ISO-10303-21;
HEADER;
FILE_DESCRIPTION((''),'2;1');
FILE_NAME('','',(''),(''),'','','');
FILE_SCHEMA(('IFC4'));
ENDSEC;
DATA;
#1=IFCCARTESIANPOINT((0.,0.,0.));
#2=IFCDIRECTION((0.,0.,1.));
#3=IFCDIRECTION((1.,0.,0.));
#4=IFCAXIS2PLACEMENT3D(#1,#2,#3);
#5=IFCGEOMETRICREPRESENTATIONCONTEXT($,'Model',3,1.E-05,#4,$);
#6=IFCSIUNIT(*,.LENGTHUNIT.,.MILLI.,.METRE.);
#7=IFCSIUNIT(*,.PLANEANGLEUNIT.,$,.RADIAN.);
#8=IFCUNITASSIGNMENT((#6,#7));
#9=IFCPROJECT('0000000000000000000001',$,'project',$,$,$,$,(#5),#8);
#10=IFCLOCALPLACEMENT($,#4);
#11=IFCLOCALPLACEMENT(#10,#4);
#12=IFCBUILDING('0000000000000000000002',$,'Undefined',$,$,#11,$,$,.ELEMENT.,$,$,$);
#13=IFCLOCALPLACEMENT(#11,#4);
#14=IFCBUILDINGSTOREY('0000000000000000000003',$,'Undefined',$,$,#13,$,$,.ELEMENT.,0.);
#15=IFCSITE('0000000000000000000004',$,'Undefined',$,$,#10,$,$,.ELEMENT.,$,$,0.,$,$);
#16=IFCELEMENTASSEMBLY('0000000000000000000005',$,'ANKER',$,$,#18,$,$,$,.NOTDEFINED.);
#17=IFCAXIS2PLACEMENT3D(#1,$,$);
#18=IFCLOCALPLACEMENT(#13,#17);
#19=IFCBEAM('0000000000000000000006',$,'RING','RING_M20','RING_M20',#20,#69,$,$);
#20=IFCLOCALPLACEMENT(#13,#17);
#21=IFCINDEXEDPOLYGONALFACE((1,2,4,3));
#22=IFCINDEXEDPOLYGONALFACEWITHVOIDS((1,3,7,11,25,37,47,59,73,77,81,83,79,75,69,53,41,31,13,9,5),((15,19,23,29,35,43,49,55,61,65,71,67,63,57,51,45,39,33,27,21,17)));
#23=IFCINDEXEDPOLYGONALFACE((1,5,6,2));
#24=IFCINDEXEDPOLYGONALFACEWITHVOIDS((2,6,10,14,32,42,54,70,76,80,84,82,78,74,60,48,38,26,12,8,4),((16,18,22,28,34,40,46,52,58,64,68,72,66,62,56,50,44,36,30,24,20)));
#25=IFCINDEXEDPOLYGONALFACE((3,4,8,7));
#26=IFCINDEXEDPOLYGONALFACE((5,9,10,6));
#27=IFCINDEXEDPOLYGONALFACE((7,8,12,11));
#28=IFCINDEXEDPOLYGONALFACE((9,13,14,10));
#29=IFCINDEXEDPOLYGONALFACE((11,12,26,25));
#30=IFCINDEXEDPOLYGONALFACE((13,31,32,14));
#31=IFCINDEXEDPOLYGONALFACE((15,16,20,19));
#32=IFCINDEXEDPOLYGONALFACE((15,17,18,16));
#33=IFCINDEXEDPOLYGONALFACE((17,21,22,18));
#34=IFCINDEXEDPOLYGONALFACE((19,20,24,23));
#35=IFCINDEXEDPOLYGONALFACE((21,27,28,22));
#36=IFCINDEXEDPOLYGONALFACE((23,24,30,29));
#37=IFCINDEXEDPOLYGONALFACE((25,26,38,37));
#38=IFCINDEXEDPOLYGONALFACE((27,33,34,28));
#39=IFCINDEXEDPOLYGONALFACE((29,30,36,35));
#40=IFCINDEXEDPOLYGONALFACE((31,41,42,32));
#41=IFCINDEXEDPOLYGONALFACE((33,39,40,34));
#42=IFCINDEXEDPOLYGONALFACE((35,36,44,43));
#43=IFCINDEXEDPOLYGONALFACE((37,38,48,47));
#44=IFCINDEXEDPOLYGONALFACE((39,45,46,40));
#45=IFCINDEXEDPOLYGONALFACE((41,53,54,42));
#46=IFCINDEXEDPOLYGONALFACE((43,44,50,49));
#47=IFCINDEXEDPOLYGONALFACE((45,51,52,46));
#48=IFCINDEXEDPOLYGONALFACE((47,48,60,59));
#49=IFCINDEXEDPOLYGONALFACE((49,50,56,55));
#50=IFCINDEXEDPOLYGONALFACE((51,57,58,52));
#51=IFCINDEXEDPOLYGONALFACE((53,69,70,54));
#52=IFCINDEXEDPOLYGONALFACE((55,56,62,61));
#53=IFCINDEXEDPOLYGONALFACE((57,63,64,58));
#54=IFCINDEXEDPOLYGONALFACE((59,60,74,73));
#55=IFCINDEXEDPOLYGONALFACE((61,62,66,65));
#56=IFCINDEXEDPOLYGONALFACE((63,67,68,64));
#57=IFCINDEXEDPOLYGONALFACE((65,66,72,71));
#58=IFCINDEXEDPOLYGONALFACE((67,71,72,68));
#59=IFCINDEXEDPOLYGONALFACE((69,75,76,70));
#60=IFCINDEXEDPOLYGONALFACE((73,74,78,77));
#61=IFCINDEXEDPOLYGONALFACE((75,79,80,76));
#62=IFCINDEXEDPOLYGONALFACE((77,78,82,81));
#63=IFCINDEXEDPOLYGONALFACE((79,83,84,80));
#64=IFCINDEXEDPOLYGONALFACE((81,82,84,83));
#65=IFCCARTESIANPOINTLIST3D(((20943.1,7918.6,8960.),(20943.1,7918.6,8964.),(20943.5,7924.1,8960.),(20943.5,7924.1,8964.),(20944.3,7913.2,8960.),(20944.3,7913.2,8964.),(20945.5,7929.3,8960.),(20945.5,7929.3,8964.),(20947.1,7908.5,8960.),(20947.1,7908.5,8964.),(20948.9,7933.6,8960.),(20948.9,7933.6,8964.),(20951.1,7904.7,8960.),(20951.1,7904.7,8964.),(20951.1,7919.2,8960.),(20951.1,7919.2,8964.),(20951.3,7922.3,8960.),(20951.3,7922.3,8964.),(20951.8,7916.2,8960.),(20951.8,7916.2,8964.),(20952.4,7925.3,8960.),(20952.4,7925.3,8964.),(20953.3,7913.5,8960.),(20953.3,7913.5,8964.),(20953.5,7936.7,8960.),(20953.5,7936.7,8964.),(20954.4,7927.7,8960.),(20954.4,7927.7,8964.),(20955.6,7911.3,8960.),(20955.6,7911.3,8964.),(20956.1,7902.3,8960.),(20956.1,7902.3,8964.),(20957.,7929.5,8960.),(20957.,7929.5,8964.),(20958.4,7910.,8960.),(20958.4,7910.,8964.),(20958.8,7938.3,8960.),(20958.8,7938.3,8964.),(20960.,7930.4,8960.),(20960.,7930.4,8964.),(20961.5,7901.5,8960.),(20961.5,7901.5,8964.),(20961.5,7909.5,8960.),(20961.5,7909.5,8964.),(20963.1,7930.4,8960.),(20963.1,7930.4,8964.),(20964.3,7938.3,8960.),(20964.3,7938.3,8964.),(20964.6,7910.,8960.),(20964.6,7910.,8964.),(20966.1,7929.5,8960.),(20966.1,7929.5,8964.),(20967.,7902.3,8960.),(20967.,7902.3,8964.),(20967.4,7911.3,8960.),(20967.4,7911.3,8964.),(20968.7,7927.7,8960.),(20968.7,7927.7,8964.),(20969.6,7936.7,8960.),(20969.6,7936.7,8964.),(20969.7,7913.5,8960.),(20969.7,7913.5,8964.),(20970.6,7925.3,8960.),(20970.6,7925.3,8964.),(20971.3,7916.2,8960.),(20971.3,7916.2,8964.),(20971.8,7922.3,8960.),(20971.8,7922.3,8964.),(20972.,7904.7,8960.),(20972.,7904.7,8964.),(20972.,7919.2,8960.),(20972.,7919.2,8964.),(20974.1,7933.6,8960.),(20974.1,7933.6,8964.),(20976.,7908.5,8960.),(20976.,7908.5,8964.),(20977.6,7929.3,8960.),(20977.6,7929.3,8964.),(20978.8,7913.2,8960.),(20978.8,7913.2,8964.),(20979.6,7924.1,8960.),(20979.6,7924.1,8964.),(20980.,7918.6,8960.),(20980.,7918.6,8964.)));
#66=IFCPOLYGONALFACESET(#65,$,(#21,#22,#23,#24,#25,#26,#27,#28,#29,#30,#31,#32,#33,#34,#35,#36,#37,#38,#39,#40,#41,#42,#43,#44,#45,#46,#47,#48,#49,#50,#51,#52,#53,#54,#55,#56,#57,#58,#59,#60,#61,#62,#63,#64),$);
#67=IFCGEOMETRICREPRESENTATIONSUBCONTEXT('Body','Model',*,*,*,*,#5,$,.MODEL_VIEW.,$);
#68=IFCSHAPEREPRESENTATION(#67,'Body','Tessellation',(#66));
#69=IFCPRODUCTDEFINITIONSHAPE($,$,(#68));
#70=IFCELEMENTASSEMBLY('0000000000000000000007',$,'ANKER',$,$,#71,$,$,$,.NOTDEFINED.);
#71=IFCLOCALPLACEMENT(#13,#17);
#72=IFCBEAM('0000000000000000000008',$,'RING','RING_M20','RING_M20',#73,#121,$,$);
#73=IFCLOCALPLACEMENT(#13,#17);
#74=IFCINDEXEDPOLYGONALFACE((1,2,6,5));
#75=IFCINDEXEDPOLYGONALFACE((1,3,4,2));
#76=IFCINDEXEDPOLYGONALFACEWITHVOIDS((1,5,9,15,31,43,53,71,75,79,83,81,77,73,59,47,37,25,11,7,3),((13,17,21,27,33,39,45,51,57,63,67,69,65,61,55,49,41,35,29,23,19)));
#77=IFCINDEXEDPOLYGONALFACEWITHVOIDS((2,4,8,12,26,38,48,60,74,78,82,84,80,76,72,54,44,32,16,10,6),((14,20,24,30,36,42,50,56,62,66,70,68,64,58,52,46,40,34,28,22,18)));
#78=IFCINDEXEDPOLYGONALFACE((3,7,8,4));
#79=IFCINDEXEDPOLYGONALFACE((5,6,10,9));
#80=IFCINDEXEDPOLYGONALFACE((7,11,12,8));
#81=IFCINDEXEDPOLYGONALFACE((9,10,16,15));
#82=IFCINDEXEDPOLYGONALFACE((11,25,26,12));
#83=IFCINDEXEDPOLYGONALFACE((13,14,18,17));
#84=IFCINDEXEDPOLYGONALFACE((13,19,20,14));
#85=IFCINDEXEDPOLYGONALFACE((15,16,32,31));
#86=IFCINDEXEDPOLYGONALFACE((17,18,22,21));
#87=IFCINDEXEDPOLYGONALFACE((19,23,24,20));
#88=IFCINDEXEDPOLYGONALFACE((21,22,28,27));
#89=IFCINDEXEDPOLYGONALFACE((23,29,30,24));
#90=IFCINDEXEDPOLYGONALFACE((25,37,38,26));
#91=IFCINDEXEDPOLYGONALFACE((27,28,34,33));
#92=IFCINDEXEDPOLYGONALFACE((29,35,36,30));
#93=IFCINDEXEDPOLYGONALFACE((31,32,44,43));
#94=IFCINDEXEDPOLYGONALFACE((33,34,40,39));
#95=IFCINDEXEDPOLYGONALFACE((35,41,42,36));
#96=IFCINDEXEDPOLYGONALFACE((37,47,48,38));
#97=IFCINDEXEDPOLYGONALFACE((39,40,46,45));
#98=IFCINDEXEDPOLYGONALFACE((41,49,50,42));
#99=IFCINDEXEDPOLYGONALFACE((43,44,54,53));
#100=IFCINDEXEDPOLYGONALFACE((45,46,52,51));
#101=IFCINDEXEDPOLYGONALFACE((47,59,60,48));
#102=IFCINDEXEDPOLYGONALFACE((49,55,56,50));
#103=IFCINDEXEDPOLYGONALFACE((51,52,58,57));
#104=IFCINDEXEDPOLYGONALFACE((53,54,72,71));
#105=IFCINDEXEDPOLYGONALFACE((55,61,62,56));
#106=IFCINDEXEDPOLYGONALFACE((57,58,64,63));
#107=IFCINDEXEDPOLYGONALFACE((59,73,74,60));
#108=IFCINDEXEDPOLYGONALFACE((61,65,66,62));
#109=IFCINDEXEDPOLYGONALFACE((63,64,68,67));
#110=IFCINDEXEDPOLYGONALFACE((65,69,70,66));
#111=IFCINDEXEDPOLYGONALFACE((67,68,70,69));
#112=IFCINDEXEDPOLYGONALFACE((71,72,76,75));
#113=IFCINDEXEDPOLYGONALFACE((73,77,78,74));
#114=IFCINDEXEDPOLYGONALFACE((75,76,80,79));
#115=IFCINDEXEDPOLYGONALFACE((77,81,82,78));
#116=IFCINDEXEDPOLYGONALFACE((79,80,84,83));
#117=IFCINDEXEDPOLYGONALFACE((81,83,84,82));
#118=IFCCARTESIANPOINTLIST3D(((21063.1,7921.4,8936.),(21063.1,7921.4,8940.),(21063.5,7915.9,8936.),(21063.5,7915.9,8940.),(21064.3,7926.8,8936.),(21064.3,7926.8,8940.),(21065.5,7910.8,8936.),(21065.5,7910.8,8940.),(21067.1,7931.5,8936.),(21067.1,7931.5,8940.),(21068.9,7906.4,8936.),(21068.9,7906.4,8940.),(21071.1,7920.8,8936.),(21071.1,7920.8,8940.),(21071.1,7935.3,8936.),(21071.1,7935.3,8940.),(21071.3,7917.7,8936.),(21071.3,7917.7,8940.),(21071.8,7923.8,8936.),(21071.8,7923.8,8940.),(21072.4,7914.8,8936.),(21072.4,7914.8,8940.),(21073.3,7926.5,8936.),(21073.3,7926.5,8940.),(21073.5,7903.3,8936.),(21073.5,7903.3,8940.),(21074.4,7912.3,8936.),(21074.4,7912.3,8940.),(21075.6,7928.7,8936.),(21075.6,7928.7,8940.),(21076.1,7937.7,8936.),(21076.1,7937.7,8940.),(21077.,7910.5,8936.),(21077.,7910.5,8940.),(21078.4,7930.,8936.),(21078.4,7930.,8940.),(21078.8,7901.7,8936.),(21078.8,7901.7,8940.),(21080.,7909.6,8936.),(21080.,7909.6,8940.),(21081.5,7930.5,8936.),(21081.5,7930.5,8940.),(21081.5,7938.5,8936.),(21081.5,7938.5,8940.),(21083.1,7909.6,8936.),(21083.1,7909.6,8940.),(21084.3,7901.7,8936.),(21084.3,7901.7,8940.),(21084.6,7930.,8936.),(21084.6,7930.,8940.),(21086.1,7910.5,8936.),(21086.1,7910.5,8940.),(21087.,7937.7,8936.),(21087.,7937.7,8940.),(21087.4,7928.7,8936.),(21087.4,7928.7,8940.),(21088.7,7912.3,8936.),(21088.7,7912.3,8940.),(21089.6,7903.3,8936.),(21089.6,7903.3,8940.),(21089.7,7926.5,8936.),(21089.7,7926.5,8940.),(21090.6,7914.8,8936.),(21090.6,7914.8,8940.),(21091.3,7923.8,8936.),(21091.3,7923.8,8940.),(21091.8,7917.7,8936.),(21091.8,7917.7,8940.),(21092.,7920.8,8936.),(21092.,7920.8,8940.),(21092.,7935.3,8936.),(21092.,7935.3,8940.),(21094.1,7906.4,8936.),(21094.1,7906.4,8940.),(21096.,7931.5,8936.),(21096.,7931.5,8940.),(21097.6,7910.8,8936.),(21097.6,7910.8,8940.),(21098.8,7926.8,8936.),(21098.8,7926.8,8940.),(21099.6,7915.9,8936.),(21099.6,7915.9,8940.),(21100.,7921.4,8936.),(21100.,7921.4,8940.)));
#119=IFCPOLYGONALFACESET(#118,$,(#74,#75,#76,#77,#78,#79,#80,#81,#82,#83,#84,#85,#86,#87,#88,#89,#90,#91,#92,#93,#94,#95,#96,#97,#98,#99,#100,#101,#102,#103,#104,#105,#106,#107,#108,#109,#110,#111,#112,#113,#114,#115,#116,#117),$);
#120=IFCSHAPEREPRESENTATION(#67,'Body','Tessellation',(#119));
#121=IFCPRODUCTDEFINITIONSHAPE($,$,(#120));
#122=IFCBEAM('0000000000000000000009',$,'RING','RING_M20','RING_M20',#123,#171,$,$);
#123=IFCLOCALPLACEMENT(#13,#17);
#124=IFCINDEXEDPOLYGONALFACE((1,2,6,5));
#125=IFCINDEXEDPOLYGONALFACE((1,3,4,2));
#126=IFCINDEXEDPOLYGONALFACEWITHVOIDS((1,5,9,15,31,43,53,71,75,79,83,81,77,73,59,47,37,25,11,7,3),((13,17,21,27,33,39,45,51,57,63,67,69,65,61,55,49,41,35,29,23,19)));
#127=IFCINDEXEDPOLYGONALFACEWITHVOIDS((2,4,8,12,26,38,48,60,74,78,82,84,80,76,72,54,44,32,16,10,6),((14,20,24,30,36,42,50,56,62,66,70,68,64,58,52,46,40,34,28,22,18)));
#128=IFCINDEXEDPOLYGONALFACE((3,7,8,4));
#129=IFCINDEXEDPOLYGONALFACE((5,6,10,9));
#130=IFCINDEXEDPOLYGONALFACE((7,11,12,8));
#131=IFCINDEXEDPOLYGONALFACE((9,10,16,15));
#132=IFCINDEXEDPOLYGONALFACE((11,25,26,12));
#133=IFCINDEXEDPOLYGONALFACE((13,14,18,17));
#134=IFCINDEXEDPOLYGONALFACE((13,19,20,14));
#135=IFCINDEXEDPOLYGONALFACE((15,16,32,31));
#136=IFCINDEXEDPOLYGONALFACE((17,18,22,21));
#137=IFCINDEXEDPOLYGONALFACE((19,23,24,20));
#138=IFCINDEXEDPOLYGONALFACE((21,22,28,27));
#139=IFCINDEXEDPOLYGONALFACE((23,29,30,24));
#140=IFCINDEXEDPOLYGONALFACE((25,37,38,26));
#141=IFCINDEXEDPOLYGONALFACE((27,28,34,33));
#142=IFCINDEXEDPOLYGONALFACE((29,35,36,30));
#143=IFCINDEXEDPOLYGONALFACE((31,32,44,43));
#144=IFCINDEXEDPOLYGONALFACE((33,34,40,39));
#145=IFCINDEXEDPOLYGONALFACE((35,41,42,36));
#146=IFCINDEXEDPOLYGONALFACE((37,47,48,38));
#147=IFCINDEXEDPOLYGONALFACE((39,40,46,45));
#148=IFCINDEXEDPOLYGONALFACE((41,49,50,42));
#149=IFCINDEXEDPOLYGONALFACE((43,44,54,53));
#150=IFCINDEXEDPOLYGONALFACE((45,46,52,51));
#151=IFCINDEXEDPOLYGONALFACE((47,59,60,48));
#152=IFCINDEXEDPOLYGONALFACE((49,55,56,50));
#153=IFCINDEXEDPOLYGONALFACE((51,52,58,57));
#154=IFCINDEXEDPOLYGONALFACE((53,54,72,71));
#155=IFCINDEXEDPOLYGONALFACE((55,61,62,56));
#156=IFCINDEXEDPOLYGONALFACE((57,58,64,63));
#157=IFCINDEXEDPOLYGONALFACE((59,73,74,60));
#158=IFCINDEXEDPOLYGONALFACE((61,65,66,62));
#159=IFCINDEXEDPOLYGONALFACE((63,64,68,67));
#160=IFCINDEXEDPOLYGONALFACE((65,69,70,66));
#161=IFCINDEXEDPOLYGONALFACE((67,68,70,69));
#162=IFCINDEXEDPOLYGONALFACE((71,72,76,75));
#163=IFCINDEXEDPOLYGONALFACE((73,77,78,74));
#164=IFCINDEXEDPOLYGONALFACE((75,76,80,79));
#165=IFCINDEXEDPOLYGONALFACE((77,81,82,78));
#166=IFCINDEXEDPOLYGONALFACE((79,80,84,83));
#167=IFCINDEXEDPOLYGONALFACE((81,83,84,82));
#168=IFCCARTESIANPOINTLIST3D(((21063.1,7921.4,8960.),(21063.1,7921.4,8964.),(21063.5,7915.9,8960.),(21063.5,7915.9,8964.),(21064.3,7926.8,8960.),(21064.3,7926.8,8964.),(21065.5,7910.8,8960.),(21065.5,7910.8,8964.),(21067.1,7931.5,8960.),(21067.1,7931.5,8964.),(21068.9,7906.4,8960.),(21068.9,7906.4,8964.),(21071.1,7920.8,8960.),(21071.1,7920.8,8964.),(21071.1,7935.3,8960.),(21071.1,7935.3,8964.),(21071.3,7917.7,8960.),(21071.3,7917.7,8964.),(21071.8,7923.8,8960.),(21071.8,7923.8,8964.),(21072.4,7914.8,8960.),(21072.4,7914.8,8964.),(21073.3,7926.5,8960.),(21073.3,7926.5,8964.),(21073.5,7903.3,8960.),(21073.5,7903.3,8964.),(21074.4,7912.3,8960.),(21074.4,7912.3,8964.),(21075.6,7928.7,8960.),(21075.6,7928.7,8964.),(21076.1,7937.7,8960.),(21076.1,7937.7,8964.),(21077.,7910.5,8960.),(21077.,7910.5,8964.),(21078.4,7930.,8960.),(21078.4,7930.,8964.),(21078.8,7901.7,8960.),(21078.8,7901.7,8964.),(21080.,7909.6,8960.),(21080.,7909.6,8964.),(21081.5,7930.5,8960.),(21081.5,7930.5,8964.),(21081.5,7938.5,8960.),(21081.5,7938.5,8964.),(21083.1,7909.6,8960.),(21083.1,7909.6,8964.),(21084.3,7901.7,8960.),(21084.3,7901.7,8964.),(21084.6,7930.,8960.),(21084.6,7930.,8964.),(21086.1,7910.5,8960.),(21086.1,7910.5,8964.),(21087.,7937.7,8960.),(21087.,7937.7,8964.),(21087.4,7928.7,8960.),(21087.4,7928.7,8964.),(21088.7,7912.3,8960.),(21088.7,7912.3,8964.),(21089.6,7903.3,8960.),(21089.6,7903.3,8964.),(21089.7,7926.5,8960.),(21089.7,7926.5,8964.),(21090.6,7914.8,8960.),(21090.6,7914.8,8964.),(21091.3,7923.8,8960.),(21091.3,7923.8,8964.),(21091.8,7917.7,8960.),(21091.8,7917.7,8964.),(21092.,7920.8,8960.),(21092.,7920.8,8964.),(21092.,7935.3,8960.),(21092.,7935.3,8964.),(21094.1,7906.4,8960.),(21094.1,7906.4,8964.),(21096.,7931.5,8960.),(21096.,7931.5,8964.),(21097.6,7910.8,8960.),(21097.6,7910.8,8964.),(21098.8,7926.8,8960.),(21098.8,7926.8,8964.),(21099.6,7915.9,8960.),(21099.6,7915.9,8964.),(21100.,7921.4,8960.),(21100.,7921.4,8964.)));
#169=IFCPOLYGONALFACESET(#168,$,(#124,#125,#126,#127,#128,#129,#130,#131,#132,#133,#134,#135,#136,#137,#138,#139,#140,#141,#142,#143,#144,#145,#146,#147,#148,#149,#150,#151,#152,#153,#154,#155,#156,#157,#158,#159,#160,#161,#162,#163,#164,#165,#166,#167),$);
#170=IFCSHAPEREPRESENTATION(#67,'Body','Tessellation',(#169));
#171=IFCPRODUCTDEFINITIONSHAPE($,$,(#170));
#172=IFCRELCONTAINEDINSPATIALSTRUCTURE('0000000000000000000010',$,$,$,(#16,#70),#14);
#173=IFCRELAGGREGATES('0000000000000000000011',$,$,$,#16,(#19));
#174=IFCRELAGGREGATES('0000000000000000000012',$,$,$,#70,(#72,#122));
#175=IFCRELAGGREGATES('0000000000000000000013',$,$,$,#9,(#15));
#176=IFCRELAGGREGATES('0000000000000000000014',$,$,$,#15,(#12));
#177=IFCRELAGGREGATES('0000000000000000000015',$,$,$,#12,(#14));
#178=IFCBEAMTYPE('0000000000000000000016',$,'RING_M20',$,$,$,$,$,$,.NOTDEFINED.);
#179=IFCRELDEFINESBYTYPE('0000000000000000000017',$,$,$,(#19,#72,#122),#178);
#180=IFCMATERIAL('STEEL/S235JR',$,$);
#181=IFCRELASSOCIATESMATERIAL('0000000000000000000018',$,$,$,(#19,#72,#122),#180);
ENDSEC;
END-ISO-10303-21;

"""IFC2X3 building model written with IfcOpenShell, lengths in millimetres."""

from ifc_helpers import new_model, si_unit, frame, origin_with_axes, origin_2d_with_axis, place, context, subcontext, project, spatial, hollow_circle, extrude, material, type_object, element, aggregate, save


model = new_model("IFC2X3")

# Units and contexts
model_context = context("Model", 3, precision=1e-05, world=origin_with_axes())
body_context = subcontext(model_context, "Body", "Model", "MODEL_VIEW")
ifc_project = project(units=[si_unit("LENGTHUNIT", "METRE", prefix="MILLI"), si_unit("PLANEANGLEUNIT", "RADIAN")], contexts=[model_context])

# Site, building, storey
site_placement = place(None, origin_with_axes())
site = spatial("IfcSite", under=ifc_project, at=site_placement, Name="Undefined", CompositionType="ELEMENT", RefElevation=0.0)
building_placement = place(site_placement, origin_with_axes())
building = spatial("IfcBuilding", under=site, at=building_placement, Name="Undefined", CompositionType="ELEMENT")
storey_placement = place(building_placement, origin_with_axes())
storey = spatial("IfcBuildingStorey", under=building, at=storey_placement, Name="Undefined", CompositionType="ELEMENT", Elevation=0.0)

# Shared definitions
ifc_material = material(Name="STEEL/S235JR")

# Element assemblies, beams
beam_type_1 = type_object("IfcBeamType", Name="RING_M20", PredefinedType="NOTDEFINED")
assembly_1_placement = place(storey_placement, frame((20961.5, 7920.0, 9010.0), z_axis=(0.0, 1.0, 0.0), x_axis=(0.0, 0.0, -1.0)))
assembly_1 = element("IfcElementAssembly", 1, at=assembly_1_placement, inside=storey, Name="ANKER", PredefinedType="NOTDEFINED")
beam_1_placement = place(storey_placement, frame((20961.5, 7920.0, 8964.0), z_axis=(1.0, 0.0, 0.0), x_axis=(0.0, 0.0, -1.0)))
beam_1 = element("IfcBeam", 2, at=beam_1_placement, type_object=beam_type_1, material=ifc_material, Name="RING", Description="RING_M20", ObjectType="RING_M20", context=body_context, shape_type="SweptSolid", body=[
    extrude(hollow_circle(Radius=18.5, WallThickness=8.0, at=origin_2d_with_axis()), frame((4.0, 0.0, 0.0), z_axis=(-1.0, 0.0, 0.0), x_axis=(0.0, -1.0, 0.0)), (0.0, 0.0, 1.0), 4.0),
])
aggregate(assembly_1, [beam_1])
assembly_2_placement = place(storey_placement, frame((21081.5, 7920.0, 9010.0), z_axis=(0.0, 1.0, 0.0), x_axis=(0.0, 0.0, -1.0)))
assembly_2 = element("IfcElementAssembly", 3, at=assembly_2_placement, inside=storey, Name="ANKER", PredefinedType="NOTDEFINED")
beam_2_placement = place(storey_placement, frame((21081.5, 7920.0, 8940.0), z_axis=(-1.0, 0.0, 0.0), x_axis=(0.0, 0.0, -1.0)))
beam_2 = element("IfcBeam", 4, at=beam_2_placement, type_object=beam_type_1, material=ifc_material, Name="RING", Description="RING_M20", ObjectType="RING_M20", context=body_context, shape_type="SweptSolid", body=[
    extrude(hollow_circle(Radius=18.5, WallThickness=8.0, at=origin_2d_with_axis()), frame((4.0, 0.0, 0.0), z_axis=(-1.0, 0.0, 0.0), x_axis=(0.0, -1.0, 0.0)), (0.0, 0.0, 1.0), 4.0),
])
beam_3_placement = place(storey_placement, frame((21081.5, 7920.0, 8964.0), z_axis=(-1.0, 0.0, 0.0), x_axis=(0.0, 0.0, -1.0)))
beam_3 = element("IfcBeam", 5, at=beam_3_placement, type_object=beam_type_1, material=ifc_material, Name="RING", Description="RING_M20", ObjectType="RING_M20", context=body_context, shape_type="SweptSolid", body=[
    extrude(hollow_circle(Radius=18.5, WallThickness=8.0, at=origin_2d_with_axis()), frame((4.0, 0.0, 0.0), z_axis=(-1.0, 0.0, 0.0), x_axis=(0.0, -1.0, 0.0)), (0.0, 0.0, 1.0), 4.0),
])
aggregate(assembly_2, [beam_2, beam_3])

save(model, "model.ifc")
